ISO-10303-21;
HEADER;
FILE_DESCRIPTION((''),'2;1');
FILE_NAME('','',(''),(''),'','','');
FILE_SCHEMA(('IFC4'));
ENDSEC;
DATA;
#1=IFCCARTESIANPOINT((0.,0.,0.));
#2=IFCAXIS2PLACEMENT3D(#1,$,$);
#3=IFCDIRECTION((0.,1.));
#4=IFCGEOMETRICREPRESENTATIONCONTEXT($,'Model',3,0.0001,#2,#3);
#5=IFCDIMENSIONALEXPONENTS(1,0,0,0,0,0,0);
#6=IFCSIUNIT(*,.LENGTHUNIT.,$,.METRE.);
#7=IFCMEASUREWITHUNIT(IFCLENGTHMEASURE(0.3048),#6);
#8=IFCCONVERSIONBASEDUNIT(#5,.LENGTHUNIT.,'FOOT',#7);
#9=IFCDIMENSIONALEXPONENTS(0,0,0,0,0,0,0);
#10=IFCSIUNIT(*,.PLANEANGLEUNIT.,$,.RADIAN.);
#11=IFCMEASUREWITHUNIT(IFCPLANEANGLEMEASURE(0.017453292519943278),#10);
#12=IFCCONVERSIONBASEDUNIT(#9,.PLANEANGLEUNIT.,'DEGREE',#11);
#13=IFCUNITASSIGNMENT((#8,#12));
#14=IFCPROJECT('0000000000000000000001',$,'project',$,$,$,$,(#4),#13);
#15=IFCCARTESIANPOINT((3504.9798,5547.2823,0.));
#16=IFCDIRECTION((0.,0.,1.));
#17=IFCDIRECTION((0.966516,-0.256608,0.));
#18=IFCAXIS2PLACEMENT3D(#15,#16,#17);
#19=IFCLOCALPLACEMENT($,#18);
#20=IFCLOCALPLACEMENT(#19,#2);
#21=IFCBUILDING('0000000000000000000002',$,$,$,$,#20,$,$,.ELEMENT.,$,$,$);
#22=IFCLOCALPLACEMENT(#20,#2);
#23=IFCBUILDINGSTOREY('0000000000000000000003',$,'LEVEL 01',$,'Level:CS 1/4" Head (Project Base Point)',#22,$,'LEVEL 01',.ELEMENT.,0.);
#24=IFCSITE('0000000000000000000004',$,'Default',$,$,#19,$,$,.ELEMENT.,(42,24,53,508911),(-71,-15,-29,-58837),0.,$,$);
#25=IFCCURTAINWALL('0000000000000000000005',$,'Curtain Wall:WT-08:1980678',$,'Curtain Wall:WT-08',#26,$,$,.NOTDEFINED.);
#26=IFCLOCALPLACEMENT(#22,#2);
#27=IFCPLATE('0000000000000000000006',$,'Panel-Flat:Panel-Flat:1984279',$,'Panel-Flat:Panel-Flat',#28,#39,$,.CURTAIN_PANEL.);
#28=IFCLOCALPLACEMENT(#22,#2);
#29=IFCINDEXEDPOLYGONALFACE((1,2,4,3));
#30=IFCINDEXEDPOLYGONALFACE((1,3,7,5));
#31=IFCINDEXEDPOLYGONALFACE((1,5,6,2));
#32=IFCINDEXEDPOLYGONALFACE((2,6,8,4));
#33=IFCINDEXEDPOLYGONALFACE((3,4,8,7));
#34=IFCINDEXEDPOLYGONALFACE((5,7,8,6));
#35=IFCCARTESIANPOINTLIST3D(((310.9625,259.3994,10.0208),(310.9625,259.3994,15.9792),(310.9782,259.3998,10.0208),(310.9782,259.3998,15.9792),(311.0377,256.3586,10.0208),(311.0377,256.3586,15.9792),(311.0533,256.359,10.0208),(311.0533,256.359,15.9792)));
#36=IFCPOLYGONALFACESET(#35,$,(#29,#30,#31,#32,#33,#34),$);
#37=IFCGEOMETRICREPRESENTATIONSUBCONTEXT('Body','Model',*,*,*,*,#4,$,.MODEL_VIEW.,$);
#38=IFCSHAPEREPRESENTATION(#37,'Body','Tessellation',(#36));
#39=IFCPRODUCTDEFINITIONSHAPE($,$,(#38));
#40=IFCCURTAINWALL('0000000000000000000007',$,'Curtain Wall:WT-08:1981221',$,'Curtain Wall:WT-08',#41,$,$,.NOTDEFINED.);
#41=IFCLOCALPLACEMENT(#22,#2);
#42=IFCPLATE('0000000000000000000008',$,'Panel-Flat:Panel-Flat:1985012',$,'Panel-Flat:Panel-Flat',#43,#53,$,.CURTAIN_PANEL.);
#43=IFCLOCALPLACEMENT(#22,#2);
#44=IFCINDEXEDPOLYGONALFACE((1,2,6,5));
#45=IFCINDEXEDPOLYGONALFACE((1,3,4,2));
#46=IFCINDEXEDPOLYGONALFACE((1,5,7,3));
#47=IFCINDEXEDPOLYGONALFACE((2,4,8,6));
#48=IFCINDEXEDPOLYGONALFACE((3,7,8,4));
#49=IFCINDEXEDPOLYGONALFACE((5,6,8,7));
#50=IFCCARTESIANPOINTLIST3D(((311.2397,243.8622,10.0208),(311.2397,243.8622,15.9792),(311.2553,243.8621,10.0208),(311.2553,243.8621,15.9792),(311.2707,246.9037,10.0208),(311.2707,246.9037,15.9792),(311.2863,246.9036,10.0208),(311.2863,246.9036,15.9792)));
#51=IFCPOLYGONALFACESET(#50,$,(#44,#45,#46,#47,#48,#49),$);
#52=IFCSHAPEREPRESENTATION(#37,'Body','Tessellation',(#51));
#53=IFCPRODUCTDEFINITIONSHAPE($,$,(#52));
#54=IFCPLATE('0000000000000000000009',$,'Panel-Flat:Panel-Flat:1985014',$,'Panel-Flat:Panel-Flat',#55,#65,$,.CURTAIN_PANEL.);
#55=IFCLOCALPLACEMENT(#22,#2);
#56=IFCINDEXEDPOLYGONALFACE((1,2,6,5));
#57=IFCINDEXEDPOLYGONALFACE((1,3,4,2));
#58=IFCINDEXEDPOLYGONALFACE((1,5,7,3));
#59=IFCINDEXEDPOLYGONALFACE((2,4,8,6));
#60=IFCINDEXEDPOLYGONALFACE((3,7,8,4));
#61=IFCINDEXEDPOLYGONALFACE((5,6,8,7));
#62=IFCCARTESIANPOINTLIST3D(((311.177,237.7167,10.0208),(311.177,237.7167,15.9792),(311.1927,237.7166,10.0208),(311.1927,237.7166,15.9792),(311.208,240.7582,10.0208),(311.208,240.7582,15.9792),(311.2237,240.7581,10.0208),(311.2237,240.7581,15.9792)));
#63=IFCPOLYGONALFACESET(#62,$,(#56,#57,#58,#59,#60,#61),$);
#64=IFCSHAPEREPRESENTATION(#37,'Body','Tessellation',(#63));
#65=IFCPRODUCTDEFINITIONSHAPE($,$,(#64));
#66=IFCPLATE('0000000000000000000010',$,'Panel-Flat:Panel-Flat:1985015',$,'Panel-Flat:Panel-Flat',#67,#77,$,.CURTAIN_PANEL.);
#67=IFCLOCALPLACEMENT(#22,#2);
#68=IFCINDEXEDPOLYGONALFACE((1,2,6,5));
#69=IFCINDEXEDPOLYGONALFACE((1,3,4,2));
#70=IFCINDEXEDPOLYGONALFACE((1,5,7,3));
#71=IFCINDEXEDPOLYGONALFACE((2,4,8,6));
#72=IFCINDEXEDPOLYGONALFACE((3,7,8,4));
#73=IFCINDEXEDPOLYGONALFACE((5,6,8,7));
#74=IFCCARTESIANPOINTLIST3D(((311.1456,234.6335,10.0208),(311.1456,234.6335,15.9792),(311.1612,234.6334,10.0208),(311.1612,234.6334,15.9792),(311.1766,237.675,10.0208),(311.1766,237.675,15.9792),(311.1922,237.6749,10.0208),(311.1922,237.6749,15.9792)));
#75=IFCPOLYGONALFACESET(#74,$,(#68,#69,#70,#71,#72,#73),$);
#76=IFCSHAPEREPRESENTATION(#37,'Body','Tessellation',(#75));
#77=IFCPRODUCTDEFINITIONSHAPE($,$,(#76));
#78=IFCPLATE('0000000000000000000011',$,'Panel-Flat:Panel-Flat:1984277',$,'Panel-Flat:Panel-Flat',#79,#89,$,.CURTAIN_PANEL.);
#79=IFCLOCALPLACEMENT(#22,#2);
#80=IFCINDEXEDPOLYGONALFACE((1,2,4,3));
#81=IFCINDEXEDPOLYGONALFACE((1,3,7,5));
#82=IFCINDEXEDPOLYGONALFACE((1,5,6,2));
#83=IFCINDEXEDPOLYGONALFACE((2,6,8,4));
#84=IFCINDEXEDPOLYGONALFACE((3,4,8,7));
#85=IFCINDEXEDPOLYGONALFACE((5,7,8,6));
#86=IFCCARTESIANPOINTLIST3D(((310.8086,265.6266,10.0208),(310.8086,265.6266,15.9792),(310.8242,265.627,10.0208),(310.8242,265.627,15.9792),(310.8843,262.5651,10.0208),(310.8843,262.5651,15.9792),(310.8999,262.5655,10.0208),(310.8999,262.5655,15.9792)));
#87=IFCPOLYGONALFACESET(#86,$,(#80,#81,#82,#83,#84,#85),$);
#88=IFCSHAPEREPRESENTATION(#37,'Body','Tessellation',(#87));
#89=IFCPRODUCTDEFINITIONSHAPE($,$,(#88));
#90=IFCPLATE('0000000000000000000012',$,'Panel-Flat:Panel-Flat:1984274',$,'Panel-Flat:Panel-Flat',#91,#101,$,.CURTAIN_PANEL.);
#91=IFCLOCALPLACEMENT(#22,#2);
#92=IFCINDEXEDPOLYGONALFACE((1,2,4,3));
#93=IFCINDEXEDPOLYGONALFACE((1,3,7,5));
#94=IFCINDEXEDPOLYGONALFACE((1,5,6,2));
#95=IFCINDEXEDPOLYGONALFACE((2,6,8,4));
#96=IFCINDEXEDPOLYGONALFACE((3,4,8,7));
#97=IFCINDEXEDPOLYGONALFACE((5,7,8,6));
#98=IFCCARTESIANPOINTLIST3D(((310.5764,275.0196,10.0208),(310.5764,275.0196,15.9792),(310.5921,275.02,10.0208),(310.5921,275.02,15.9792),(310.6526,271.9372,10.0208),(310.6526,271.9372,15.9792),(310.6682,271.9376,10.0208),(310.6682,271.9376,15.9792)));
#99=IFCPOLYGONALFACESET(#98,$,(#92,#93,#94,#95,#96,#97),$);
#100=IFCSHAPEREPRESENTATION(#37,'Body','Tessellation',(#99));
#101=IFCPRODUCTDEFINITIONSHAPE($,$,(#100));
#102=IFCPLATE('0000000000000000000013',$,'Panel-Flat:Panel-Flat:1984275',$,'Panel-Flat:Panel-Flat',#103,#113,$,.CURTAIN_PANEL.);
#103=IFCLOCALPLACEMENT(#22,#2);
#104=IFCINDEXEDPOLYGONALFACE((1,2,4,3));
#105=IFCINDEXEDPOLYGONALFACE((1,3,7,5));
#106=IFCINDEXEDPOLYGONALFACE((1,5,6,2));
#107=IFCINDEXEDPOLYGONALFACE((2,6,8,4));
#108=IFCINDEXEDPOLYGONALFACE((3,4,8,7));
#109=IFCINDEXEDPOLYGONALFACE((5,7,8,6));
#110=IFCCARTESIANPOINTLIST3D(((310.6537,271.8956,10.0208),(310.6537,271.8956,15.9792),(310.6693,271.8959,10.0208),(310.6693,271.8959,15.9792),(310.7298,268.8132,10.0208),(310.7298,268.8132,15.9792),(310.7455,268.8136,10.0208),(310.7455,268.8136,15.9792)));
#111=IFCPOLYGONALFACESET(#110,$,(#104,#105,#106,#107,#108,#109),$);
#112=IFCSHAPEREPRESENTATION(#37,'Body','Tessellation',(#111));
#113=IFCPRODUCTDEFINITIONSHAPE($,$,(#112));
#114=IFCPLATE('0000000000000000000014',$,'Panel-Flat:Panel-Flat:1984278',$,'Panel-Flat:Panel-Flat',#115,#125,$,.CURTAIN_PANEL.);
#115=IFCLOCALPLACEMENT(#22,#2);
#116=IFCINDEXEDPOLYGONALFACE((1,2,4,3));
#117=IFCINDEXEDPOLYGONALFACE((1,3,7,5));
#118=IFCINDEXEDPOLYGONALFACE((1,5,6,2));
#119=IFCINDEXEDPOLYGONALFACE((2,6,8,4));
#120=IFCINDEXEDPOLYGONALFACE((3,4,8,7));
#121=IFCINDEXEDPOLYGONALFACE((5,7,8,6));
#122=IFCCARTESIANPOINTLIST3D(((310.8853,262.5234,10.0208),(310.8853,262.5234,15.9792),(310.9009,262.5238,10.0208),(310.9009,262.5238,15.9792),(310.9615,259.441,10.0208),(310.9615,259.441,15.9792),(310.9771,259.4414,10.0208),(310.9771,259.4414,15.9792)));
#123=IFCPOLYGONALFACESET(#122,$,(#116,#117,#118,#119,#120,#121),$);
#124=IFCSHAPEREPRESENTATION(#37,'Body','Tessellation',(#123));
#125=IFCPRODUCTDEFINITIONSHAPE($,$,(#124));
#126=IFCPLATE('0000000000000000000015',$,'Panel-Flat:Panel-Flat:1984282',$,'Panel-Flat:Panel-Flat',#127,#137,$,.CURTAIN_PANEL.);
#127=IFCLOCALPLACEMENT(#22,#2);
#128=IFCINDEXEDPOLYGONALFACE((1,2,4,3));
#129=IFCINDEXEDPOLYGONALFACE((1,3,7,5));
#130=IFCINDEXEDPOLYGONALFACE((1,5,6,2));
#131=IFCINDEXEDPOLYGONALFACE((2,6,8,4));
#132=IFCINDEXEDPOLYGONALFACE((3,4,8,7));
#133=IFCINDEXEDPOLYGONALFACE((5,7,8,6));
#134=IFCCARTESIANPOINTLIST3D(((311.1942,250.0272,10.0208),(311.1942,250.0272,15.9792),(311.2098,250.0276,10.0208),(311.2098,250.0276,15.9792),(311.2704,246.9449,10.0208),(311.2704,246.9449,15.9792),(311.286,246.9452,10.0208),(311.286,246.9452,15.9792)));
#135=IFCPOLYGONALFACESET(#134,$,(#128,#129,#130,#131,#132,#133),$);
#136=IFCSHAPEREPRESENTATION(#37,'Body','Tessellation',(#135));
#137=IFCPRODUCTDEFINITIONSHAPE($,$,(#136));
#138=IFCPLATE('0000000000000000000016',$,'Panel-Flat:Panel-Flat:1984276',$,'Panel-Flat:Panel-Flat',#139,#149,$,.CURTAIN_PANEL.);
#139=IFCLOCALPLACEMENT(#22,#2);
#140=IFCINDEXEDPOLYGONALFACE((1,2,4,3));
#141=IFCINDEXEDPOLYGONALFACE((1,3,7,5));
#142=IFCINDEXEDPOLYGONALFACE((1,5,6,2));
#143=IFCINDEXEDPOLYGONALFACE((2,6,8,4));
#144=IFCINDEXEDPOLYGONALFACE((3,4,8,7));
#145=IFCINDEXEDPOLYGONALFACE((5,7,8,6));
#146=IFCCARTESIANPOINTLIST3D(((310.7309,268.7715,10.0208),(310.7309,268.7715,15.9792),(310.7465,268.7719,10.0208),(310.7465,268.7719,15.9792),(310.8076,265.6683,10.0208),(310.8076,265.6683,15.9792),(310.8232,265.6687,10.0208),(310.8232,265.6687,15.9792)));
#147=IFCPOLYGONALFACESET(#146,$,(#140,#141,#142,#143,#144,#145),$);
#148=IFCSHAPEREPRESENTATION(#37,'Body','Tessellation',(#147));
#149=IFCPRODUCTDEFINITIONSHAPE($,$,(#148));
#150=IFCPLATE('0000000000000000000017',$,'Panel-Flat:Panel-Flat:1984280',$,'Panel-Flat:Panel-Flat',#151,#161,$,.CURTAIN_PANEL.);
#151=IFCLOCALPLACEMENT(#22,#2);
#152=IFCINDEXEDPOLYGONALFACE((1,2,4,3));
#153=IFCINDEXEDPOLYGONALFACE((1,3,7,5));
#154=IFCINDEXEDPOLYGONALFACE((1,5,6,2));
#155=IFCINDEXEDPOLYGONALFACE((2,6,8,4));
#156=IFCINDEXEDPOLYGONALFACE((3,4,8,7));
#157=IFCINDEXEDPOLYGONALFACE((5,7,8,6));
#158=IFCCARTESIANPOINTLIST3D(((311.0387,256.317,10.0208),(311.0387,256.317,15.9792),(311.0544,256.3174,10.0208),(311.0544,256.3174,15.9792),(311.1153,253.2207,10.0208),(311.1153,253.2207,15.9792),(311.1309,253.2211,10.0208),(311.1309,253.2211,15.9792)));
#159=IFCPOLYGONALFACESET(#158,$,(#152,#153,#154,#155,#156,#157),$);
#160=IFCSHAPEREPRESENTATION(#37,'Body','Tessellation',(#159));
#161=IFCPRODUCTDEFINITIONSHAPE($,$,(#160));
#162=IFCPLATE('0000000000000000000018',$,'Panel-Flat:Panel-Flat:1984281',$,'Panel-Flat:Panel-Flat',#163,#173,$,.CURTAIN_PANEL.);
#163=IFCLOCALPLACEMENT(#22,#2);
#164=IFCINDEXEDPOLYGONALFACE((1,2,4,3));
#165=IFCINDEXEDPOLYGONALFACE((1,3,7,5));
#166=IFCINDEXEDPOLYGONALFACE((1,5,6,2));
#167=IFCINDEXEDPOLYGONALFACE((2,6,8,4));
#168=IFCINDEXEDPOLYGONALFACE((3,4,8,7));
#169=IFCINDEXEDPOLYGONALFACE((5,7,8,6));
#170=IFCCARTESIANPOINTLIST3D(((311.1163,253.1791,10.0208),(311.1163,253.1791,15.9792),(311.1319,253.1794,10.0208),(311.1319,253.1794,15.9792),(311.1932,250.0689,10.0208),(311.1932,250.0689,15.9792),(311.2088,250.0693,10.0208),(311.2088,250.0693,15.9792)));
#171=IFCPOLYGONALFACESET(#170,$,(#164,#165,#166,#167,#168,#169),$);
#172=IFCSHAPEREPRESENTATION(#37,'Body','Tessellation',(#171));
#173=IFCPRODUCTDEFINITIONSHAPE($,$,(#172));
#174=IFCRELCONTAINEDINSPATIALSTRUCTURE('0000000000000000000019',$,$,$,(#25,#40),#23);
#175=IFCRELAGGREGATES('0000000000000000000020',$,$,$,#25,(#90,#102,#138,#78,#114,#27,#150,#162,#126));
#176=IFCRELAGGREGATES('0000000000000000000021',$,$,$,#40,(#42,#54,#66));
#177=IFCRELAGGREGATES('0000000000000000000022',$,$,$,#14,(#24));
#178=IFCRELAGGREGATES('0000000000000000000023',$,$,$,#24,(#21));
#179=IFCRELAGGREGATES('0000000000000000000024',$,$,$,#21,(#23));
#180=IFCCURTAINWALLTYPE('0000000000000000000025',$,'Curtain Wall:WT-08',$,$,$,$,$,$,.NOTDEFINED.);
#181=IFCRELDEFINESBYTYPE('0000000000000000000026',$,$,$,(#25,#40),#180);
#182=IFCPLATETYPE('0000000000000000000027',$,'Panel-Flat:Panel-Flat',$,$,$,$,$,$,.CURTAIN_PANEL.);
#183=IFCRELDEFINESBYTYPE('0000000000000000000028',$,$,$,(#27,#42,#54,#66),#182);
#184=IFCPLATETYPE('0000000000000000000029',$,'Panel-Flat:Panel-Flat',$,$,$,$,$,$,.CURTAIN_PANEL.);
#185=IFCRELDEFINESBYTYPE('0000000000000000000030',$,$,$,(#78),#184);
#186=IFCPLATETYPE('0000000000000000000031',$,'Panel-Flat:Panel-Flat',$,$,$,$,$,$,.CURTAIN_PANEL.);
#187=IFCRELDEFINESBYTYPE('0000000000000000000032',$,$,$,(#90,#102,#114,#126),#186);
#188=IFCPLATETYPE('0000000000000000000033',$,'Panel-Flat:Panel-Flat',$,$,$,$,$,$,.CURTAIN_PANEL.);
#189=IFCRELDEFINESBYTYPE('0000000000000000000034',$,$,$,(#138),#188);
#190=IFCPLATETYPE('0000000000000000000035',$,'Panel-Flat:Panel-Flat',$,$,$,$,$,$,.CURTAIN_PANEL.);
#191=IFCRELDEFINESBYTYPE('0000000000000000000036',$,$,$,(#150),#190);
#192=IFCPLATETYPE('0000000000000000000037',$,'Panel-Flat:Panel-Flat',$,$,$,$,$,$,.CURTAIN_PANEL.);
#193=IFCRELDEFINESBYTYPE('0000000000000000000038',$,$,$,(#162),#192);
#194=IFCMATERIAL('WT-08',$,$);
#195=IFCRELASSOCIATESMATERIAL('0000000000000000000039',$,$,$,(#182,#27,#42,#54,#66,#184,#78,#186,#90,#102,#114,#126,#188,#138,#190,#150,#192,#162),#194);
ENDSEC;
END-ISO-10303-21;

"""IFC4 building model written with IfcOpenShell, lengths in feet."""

from ifc_helpers import new_model, entity, si_unit, converted_unit, direction, frame, origin, place, context, subcontext, project, spatial, indexed_curve, outline, extrude, source, transform, mapped, material, type_object, type_shapes, element, aggregate, save


model = new_model("IFC4")

# Units and contexts
model_context = context("Model", 3, precision=0.0001, world=origin(), true_north=direction((0.0, 1.0)))
body_context = subcontext(model_context, "Body", "Model", "MODEL_VIEW")
ifc_project = project(units=[converted_unit("LENGTHUNIT", "FOOT", entity("IfcLengthMeasure", 0.3048), si_unit("LENGTHUNIT", "METRE"), dimensions=[1, 0, 0, 0, 0, 0, 0]), converted_unit("PLANEANGLEUNIT", "DEGREE", entity("IfcPlaneAngleMeasure", 0.017453292519943278), si_unit("PLANEANGLEUNIT", "RADIAN"), dimensions=[0, 0, 0, 0, 0, 0, 0])], contexts=[model_context])

# Site, building, storey
site_placement = place(None, frame((3504.9798, 5547.2823, 0.0), z_axis=(0.0, 0.0, 1.0), x_axis=(0.966516, -0.256608, 0.0)))
site = spatial("IfcSite", under=ifc_project, at=site_placement, Name="Default", CompositionType="ELEMENT", RefLatitude=(42, 24, 53, 508911), RefLongitude=(-71, -15, -29, -58837), RefElevation=0.0)
building_placement = place(site_placement, origin())
building = spatial("IfcBuilding", under=site, at=building_placement, CompositionType="ELEMENT")
storey_placement = place(building_placement, origin())
storey = spatial("IfcBuildingStorey", under=building, at=storey_placement, Name="LEVEL 01", ObjectType="Level:CS 1/4\" Head (Project Base Point)", LongName="LEVEL 01", CompositionType="ELEMENT", Elevation=0.0)

# Curtain walls, plates
curtain_wall_type_1 = type_object("IfcCurtainWallType", Name="Curtain Wall:WT-08", PredefinedType="NOTDEFINED")
curtain_wall_1_placement = place(storey_placement, origin())
curtain_wall_1 = element("IfcCurtainWall", 1, at=curtain_wall_1_placement, inside=storey, type_object=curtain_wall_type_1, Name="Curtain Wall:WT-08:1980678", ObjectType="Curtain Wall:WT-08", PredefinedType="NOTDEFINED")
ifc_material_1 = material(Name="WT-08")
plate_type_1 = type_object("IfcPlateType", Name="Panel-Flat:Panel-Flat", PredefinedType="CURTAIN_PANEL", material=ifc_material_1)
shared_shape_1 = source(origin(), body_context, "Body", "SweptSolid", [
    extrude(outline(indexed_curve([(-0.0078, -1.5208), (0.0078, -1.5208), (0.0078, 1.5208), (-0.0078, 1.5208), (-0.0078, -1.5208)], self_intersect=False)), frame((1.5208, 0.0078, 0.0), z_axis=(0.0, 0.0, 1.0), x_axis=(0.0, -1.0, 0.0)), (0.0, 0.0, 1.0), 5.9583),
])
type_shapes(plate_type_1, [shared_shape_1])
plate_1_placement = place(curtain_wall_1_placement, frame((310.9625, 259.3994, 10.0208), z_axis=(0.0, 0.0, 1.0), x_axis=(0.024711, -0.999695, 0.0)))
plate_1 = element("IfcPlate", 2, at=plate_1_placement, type_object=plate_type_1, material=ifc_material_1, Name="Panel-Flat:Panel-Flat:1984279", ObjectType="Panel-Flat:Panel-Flat", PredefinedType="CURTAIN_PANEL", context=body_context, shape_type="MappedRepresentation", body=[
    mapped(shared_shape_1, transform((0.0, 0.0, 0.0), scale=1.0)),
])
curtain_wall_2_placement = place(storey_placement, origin())
curtain_wall_2 = element("IfcCurtainWall", 3, at=curtain_wall_2_placement, inside=storey, type_object=curtain_wall_type_1, Name="Curtain Wall:WT-08:1981221", ObjectType="Curtain Wall:WT-08", PredefinedType="NOTDEFINED")
plate_2_placement = place(curtain_wall_2_placement, frame((311.2707, 246.9037, 10.0208), z_axis=(0.0, 0.0, 1.0), x_axis=(-0.010193, -0.999948, 0.0)))
plate_2 = element("IfcPlate", 4, at=plate_2_placement, type_object=plate_type_1, material=ifc_material_1, Name="Panel-Flat:Panel-Flat:1985012", ObjectType="Panel-Flat:Panel-Flat", PredefinedType="CURTAIN_PANEL", context=body_context, shape_type="MappedRepresentation", body=[
    mapped(shared_shape_1, transform((0.0, 0.0, 0.0), scale=1.0)),
])
plate_3_placement = place(curtain_wall_2_placement, frame((311.208, 240.7582, 10.0208), z_axis=(0.0, 0.0, 1.0), x_axis=(-0.010193, -0.999948, 0.0)))
plate_3 = element("IfcPlate", 5, at=plate_3_placement, type_object=plate_type_1, material=ifc_material_1, Name="Panel-Flat:Panel-Flat:1985014", ObjectType="Panel-Flat:Panel-Flat", PredefinedType="CURTAIN_PANEL", context=body_context, shape_type="MappedRepresentation", body=[
    mapped(shared_shape_1, transform((0.0, 0.0, 0.0), scale=1.0)),
])
plate_4_placement = place(curtain_wall_2_placement, frame((311.1766, 237.675, 10.0208), z_axis=(0.0, 0.0, 1.0), x_axis=(-0.010193, -0.999948, 0.0)))
plate_4 = element("IfcPlate", 6, at=plate_4_placement, type_object=plate_type_1, material=ifc_material_1, Name="Panel-Flat:Panel-Flat:1985015", ObjectType="Panel-Flat:Panel-Flat", PredefinedType="CURTAIN_PANEL", context=body_context, shape_type="MappedRepresentation", body=[
    mapped(shared_shape_1, transform((0.0, 0.0, 0.0), scale=1.0)),
])

# Plates
plate_type_2 = type_object("IfcPlateType", Name="Panel-Flat:Panel-Flat", PredefinedType="CURTAIN_PANEL", material=ifc_material_1)
shared_shape_2 = source(origin(), body_context, "Body", "SweptSolid", [
    extrude(outline(indexed_curve([(-0.0078, -1.5313), (0.0078, -1.5313), (0.0078, 1.5313), (-0.0078, 1.5313), (-0.0078, -1.5313)], self_intersect=False)), frame((1.5313, 0.0078, 0.0), z_axis=(0.0, 0.0, 1.0), x_axis=(0.0, -1.0, 0.0)), (0.0, 0.0, 1.0), 5.9583),
])
type_shapes(plate_type_2, [shared_shape_2])
plate_5_placement = place(curtain_wall_1_placement, frame((310.8086, 265.6266, 10.0208), z_axis=(0.0, 0.0, 1.0), x_axis=(0.024711, -0.999695, 0.0)))
plate_5 = element("IfcPlate", 7, at=plate_5_placement, type_object=plate_type_2, material=ifc_material_1, Name="Panel-Flat:Panel-Flat:1984277", ObjectType="Panel-Flat:Panel-Flat", PredefinedType="CURTAIN_PANEL", context=body_context, shape_type="MappedRepresentation", body=[
    mapped(shared_shape_2, transform((0.0, 0.0, 0.0), scale=1.0)),
])
plate_type_3 = type_object("IfcPlateType", Name="Panel-Flat:Panel-Flat", PredefinedType="CURTAIN_PANEL", material=ifc_material_1)
shared_shape_3 = source(origin(), body_context, "Body", "SweptSolid", [
    extrude(outline(indexed_curve([(-0.0078, -1.5417), (0.0078, -1.5417), (0.0078, 1.5417), (-0.0078, 1.5417), (-0.0078, -1.5417)], self_intersect=False)), frame((1.5417, 0.0078, 0.0), z_axis=(0.0, 0.0, 1.0), x_axis=(0.0, -1.0, 0.0)), (0.0, 0.0, 1.0), 5.9583),
])
type_shapes(plate_type_3, [shared_shape_3])
plate_6_placement = place(curtain_wall_1_placement, frame((310.5764, 275.0196, 10.0208), z_axis=(0.0, 0.0, 1.0), x_axis=(0.024711, -0.999695, 0.0)))
plate_6 = element("IfcPlate", 8, at=plate_6_placement, type_object=plate_type_3, material=ifc_material_1, Name="Panel-Flat:Panel-Flat:1984274", ObjectType="Panel-Flat:Panel-Flat", PredefinedType="CURTAIN_PANEL", context=body_context, shape_type="MappedRepresentation", body=[
    mapped(shared_shape_3, transform((0.0, 0.0, 0.0), scale=1.0)),
])
plate_7_placement = place(curtain_wall_1_placement, frame((310.6537, 271.8956, 10.0208), z_axis=(0.0, 0.0, 1.0), x_axis=(0.024711, -0.999695, 0.0)))
plate_7 = element("IfcPlate", 9, at=plate_7_placement, type_object=plate_type_3, material=ifc_material_1, Name="Panel-Flat:Panel-Flat:1984275", ObjectType="Panel-Flat:Panel-Flat", PredefinedType="CURTAIN_PANEL", context=body_context, shape_type="MappedRepresentation", body=[
    mapped(shared_shape_3, transform((0.0, 0.0, 0.0), scale=1.0)),
])
plate_8_placement = place(curtain_wall_1_placement, frame((310.8853, 262.5234, 10.0208), z_axis=(0.0, 0.0, 1.0), x_axis=(0.024711, -0.999695, 0.0)))
plate_8 = element("IfcPlate", 10, at=plate_8_placement, type_object=plate_type_3, material=ifc_material_1, Name="Panel-Flat:Panel-Flat:1984278", ObjectType="Panel-Flat:Panel-Flat", PredefinedType="CURTAIN_PANEL", context=body_context, shape_type="MappedRepresentation", body=[
    mapped(shared_shape_3, transform((0.0, 0.0, 0.0), scale=1.0)),
])
plate_9_placement = place(curtain_wall_1_placement, frame((311.1942, 250.0272, 10.0208), z_axis=(0.0, 0.0, 1.0), x_axis=(0.024711, -0.999695, 0.0)))
plate_9 = element("IfcPlate", 11, at=plate_9_placement, type_object=plate_type_3, material=ifc_material_1, Name="Panel-Flat:Panel-Flat:1984282", ObjectType="Panel-Flat:Panel-Flat", PredefinedType="CURTAIN_PANEL", context=body_context, shape_type="MappedRepresentation", body=[
    mapped(shared_shape_3, transform((0.0, 0.0, 0.0), scale=1.0)),
])
plate_type_4 = type_object("IfcPlateType", Name="Panel-Flat:Panel-Flat", PredefinedType="CURTAIN_PANEL", material=ifc_material_1)
shared_shape_4 = source(origin(), body_context, "Body", "SweptSolid", [
    extrude(outline(indexed_curve([(-0.0078, -1.5521), (0.0078, -1.5521), (0.0078, 1.5521), (-0.0078, 1.5521), (-0.0078, -1.5521)], self_intersect=False)), frame((1.5521, 0.0078, 0.0), z_axis=(0.0, 0.0, 1.0), x_axis=(0.0, -1.0, 0.0)), (0.0, 0.0, 1.0), 5.9583),
])
type_shapes(plate_type_4, [shared_shape_4])
plate_10_placement = place(curtain_wall_1_placement, frame((310.7309, 268.7715, 10.0208), z_axis=(0.0, 0.0, 1.0), x_axis=(0.024711, -0.999695, 0.0)))
plate_10 = element("IfcPlate", 12, at=plate_10_placement, type_object=plate_type_4, material=ifc_material_1, Name="Panel-Flat:Panel-Flat:1984276", ObjectType="Panel-Flat:Panel-Flat", PredefinedType="CURTAIN_PANEL", context=body_context, shape_type="MappedRepresentation", body=[
    mapped(shared_shape_4, transform((0.0, 0.0, 0.0), scale=1.0)),
])
plate_type_5 = type_object("IfcPlateType", Name="Panel-Flat:Panel-Flat", PredefinedType="CURTAIN_PANEL", material=ifc_material_1)
shared_shape_5 = source(origin(), body_context, "Body", "SweptSolid", [
    extrude(outline(indexed_curve([(-0.0078, -1.5486), (0.0078, -1.5486), (0.0078, 1.5486), (-0.0078, 1.5486), (-0.0078, -1.5486)], self_intersect=False)), frame((1.5486, 0.0078, 0.0), z_axis=(0.0, 0.0, 1.0), x_axis=(0.0, -1.0, 0.0)), (0.0, 0.0, 1.0), 5.9583),
])
type_shapes(plate_type_5, [shared_shape_5])
plate_11_placement = place(curtain_wall_1_placement, frame((311.0387, 256.317, 10.0208), z_axis=(0.0, 0.0, 1.0), x_axis=(0.024711, -0.999695, 0.0)))
plate_11 = element("IfcPlate", 13, at=plate_11_placement, type_object=plate_type_5, material=ifc_material_1, Name="Panel-Flat:Panel-Flat:1984280", ObjectType="Panel-Flat:Panel-Flat", PredefinedType="CURTAIN_PANEL", context=body_context, shape_type="MappedRepresentation", body=[
    mapped(shared_shape_5, transform((0.0, 0.0, 0.0), scale=1.0)),
])
plate_type_6 = type_object("IfcPlateType", Name="Panel-Flat:Panel-Flat", PredefinedType="CURTAIN_PANEL", material=ifc_material_1)
shared_shape_6 = source(origin(), body_context, "Body", "SweptSolid", [
    extrude(outline(indexed_curve([(-0.0078, -1.5556), (0.0078, -1.5556), (0.0078, 1.5556), (-0.0078, 1.5556), (-0.0078, -1.5556)], self_intersect=False)), frame((1.5556, 0.0078, 0.0), z_axis=(0.0, 0.0, 1.0), x_axis=(0.0, -1.0, 0.0)), (0.0, 0.0, 1.0), 5.9583),
])
type_shapes(plate_type_6, [shared_shape_6])
plate_12_placement = place(curtain_wall_1_placement, frame((311.1163, 253.1791, 10.0208), z_axis=(0.0, 0.0, 1.0), x_axis=(0.024711, -0.999695, 0.0)))
plate_12 = element("IfcPlate", 14, at=plate_12_placement, type_object=plate_type_6, material=ifc_material_1, Name="Panel-Flat:Panel-Flat:1984281", ObjectType="Panel-Flat:Panel-Flat", PredefinedType="CURTAIN_PANEL", context=body_context, shape_type="MappedRepresentation", body=[
    mapped(shared_shape_6, transform((0.0, 0.0, 0.0), scale=1.0)),
])
aggregate(curtain_wall_1, [plate_6, plate_7, plate_10, plate_5, plate_8, plate_1, plate_11, plate_12, plate_9])
aggregate(curtain_wall_2, [plate_2, plate_3, plate_4])

save(model, "model.ifc")
